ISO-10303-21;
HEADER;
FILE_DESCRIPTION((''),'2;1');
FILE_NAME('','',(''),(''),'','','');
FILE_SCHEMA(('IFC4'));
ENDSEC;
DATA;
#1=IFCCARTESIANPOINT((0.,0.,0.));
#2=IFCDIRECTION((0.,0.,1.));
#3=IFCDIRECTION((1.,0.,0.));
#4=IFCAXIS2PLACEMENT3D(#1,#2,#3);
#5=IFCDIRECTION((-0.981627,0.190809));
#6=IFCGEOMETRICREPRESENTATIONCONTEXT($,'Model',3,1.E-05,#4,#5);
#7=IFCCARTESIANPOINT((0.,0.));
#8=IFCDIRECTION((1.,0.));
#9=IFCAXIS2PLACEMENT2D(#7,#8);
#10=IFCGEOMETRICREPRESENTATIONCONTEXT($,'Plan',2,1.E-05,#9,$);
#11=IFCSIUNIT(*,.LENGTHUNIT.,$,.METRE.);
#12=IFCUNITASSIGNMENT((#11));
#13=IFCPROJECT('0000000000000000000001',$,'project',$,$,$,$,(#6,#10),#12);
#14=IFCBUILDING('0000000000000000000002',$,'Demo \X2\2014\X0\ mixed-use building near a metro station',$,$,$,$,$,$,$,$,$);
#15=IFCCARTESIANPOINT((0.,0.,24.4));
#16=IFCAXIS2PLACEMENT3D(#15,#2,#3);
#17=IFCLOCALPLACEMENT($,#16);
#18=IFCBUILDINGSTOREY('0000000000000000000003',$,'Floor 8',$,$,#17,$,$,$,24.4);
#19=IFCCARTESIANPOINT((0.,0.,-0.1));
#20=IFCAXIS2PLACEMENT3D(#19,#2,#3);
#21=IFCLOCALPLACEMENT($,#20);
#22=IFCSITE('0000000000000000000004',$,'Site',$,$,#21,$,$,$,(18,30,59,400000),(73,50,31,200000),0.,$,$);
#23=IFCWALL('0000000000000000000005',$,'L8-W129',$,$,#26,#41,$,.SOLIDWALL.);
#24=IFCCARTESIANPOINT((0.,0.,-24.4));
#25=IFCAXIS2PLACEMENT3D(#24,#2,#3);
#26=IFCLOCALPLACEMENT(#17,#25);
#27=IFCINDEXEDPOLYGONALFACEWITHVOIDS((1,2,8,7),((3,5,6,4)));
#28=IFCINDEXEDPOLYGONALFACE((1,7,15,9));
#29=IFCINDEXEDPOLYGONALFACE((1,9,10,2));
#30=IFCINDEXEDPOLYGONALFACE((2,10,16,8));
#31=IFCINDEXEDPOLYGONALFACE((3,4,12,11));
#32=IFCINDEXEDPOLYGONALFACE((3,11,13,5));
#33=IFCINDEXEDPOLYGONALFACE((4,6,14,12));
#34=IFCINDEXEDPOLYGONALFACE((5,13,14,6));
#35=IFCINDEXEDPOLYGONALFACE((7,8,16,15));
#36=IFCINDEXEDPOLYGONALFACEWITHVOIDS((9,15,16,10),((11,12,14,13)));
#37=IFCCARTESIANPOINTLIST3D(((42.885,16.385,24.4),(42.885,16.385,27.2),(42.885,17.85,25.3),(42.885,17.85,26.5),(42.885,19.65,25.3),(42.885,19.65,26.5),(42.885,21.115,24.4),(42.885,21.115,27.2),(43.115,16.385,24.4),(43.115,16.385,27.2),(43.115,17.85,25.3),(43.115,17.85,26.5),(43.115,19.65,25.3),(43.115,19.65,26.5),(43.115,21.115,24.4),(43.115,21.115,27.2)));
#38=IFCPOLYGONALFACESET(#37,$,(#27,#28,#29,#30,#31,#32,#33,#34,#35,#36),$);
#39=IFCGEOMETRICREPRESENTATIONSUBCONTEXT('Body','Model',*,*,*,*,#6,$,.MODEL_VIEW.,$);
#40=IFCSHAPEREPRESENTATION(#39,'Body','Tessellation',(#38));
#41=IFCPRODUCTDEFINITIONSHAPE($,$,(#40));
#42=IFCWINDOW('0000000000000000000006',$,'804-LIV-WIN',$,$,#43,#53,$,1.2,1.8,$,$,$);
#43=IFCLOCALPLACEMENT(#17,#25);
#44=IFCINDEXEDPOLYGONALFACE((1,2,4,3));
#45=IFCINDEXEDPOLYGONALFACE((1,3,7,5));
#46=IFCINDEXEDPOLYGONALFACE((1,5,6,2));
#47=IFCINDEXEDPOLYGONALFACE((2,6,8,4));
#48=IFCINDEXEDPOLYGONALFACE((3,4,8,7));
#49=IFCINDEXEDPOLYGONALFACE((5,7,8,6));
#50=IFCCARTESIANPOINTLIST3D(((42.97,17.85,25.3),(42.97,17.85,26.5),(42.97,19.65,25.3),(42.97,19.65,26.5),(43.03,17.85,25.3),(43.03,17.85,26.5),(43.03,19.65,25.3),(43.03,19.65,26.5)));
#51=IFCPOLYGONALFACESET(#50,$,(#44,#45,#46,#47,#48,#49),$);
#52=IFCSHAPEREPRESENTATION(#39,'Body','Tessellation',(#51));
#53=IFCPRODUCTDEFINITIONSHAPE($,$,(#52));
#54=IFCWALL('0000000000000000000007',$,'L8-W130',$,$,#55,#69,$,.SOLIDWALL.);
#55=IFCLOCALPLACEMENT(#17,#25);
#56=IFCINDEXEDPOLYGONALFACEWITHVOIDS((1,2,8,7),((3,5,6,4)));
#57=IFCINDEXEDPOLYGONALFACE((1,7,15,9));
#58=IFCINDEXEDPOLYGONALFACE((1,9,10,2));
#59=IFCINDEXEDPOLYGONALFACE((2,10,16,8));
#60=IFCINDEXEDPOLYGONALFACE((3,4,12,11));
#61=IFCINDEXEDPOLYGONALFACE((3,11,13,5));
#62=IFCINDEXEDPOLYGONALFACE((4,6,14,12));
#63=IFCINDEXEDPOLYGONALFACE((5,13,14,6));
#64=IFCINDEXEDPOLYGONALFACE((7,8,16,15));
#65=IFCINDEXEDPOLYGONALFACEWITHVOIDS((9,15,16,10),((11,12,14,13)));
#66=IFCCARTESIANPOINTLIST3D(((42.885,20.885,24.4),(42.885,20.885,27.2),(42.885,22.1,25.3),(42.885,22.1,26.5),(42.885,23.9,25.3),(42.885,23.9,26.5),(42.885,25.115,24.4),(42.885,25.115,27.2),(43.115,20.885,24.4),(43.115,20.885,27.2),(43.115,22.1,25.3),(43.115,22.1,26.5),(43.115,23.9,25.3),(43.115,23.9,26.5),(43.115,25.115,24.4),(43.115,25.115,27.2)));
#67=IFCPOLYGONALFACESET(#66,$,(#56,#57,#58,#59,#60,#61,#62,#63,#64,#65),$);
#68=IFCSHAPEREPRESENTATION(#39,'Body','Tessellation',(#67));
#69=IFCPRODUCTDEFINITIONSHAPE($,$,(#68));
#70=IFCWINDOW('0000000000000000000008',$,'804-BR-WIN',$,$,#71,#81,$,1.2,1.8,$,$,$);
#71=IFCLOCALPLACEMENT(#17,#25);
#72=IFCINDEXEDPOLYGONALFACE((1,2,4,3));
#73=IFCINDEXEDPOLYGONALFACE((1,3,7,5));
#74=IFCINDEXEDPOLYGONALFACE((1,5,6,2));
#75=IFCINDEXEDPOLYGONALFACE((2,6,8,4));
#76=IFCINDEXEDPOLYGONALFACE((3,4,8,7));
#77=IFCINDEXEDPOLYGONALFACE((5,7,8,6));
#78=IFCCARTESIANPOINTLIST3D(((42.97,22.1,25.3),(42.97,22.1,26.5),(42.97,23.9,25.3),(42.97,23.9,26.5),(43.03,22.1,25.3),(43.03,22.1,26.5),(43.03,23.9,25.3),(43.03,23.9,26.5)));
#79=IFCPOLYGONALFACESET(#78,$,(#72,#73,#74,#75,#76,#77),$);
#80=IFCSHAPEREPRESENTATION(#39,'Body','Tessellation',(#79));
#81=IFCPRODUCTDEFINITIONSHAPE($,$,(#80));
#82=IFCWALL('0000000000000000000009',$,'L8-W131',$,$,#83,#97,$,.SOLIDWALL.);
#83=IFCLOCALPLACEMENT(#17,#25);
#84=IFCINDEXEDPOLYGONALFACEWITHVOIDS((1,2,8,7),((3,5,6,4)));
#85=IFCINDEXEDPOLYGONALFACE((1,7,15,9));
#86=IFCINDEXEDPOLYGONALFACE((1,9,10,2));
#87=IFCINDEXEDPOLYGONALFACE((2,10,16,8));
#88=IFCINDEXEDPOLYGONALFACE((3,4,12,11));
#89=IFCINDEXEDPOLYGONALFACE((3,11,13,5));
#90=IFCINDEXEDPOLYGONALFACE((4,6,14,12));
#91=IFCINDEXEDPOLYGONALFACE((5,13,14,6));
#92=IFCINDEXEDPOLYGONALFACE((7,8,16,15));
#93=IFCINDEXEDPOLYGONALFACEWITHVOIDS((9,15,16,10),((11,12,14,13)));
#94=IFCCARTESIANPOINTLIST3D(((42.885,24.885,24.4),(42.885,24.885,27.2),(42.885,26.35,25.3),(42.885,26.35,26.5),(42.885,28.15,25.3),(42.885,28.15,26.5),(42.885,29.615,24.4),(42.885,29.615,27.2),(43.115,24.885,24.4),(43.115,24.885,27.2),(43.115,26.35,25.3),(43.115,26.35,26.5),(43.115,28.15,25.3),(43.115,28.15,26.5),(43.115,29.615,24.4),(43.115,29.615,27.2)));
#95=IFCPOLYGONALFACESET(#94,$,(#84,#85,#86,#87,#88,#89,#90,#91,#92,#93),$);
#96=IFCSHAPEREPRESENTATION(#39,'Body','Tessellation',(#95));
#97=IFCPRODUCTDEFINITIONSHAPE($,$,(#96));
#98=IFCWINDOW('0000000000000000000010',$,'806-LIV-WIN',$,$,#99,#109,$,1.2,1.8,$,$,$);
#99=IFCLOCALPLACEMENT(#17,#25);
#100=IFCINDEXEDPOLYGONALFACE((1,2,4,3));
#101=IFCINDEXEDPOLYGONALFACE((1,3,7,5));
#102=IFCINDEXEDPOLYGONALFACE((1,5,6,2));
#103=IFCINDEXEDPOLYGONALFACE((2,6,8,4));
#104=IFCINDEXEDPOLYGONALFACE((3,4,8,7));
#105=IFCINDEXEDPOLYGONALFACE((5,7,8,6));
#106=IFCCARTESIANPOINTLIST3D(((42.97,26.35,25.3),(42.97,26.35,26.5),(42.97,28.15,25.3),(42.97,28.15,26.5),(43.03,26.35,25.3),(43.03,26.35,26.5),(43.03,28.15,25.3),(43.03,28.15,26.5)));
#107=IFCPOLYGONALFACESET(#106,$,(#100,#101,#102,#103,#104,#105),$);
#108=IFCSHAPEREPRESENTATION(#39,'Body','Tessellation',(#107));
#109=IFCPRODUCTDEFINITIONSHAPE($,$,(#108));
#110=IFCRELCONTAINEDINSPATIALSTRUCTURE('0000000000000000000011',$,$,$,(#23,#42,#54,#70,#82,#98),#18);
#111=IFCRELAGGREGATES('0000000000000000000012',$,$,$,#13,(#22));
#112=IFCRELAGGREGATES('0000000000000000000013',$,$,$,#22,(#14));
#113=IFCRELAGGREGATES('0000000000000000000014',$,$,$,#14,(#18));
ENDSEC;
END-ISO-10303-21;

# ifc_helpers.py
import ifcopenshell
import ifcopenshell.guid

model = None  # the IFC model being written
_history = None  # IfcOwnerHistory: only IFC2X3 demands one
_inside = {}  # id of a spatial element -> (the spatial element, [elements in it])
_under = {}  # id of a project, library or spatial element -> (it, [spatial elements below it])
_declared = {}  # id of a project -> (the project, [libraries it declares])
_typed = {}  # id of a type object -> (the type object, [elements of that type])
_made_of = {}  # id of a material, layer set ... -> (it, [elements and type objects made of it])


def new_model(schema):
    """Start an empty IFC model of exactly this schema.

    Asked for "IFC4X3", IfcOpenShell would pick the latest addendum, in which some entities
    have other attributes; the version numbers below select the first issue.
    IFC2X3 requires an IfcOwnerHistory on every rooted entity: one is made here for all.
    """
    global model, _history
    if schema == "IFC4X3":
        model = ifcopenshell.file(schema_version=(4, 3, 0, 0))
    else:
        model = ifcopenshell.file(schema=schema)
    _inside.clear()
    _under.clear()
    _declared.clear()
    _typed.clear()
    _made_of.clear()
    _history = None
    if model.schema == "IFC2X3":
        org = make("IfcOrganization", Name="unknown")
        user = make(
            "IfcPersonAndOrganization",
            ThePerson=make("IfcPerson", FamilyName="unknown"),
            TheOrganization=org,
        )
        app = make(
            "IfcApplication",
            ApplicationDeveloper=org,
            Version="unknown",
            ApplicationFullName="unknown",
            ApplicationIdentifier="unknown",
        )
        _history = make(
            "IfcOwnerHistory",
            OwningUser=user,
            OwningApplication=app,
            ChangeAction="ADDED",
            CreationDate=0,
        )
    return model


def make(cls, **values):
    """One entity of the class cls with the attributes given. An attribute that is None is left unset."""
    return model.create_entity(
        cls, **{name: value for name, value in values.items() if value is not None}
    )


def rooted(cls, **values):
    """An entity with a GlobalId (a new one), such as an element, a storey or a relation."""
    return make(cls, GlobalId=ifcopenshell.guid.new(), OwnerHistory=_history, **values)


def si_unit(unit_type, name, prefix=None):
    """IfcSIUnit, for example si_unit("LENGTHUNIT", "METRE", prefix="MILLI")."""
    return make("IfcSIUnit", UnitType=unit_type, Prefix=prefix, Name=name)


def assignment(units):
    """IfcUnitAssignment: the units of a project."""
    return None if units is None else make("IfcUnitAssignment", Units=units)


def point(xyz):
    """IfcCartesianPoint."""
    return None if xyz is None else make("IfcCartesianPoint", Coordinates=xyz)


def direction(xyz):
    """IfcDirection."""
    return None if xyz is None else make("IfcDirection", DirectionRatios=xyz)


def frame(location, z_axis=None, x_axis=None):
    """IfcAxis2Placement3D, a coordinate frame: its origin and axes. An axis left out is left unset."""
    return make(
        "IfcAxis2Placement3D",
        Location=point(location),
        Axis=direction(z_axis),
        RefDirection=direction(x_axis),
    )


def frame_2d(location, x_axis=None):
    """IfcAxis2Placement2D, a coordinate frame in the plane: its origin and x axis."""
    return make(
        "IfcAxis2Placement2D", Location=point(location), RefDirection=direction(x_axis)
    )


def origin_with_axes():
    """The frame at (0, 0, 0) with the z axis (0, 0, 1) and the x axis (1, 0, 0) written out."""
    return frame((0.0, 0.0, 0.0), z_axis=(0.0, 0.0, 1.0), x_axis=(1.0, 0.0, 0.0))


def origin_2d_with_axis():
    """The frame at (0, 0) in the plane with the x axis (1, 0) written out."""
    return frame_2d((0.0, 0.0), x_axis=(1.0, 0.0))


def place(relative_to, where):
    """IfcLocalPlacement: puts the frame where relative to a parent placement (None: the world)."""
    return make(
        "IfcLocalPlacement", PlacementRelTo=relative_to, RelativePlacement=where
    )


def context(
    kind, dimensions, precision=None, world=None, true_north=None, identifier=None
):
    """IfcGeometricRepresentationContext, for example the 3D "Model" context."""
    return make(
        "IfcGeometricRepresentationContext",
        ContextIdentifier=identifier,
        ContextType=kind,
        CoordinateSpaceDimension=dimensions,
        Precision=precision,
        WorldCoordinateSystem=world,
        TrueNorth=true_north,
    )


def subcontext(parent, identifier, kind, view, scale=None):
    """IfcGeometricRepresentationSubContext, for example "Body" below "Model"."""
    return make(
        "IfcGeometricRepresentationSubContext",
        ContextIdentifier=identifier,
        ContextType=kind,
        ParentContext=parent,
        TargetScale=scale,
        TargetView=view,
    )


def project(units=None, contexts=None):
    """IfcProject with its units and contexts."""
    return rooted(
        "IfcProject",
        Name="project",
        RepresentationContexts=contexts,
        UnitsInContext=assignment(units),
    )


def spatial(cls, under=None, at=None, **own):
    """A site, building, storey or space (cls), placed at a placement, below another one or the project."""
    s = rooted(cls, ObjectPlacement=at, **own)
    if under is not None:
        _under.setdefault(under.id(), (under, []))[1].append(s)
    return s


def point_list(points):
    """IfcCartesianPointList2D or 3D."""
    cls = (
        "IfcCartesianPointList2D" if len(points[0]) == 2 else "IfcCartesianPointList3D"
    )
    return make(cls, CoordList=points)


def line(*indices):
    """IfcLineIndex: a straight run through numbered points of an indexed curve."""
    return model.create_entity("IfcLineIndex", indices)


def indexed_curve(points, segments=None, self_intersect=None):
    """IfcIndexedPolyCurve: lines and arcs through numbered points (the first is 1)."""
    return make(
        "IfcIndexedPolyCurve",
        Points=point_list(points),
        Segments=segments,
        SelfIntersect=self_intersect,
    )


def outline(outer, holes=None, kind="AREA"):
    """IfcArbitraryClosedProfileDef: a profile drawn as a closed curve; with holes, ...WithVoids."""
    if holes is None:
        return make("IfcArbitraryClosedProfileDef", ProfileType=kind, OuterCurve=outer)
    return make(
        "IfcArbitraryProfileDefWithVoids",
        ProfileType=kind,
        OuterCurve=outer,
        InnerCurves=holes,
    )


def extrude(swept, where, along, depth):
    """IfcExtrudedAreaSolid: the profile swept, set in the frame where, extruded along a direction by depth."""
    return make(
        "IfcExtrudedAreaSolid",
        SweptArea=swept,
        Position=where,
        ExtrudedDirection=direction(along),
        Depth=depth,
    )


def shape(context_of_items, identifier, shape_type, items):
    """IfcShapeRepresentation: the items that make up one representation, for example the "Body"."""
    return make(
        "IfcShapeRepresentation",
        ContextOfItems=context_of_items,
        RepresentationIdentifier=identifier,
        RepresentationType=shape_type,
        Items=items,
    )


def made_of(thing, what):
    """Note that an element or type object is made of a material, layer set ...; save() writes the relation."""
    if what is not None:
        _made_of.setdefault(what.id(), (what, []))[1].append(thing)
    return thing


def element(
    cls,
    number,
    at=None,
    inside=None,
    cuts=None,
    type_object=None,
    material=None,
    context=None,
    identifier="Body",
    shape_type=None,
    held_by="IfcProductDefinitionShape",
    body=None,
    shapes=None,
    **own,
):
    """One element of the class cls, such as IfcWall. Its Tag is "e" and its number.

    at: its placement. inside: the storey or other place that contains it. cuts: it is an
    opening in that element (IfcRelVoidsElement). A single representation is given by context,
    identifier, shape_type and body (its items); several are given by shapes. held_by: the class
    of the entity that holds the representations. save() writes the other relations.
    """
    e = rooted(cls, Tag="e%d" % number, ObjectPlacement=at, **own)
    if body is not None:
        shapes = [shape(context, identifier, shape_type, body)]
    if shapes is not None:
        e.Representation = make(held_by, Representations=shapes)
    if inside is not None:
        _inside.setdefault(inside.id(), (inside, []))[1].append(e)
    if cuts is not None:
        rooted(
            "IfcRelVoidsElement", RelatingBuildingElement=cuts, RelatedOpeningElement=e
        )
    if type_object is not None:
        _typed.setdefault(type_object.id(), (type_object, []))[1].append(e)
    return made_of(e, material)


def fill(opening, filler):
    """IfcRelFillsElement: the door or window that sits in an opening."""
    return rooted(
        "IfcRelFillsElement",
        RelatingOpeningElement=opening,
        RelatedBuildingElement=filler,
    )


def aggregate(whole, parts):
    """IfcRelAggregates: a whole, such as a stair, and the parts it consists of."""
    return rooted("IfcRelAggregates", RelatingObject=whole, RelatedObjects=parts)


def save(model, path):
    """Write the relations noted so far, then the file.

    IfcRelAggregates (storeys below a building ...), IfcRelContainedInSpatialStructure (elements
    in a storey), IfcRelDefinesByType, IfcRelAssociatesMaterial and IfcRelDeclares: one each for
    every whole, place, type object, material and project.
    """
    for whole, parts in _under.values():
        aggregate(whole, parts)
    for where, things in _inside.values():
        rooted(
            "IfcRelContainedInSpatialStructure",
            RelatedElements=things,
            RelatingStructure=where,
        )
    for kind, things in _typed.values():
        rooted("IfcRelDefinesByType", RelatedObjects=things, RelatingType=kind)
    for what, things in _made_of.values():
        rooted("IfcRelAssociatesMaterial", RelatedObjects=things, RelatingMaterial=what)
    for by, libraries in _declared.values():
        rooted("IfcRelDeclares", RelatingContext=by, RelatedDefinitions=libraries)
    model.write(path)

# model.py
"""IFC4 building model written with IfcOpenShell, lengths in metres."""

from ifc_helpers import new_model, si_unit, direction, frame, origin_with_axes, origin_2d_with_axis, place, context, subcontext, project, spatial, line, indexed_curve, outline, extrude, element, fill, save


model = new_model("IFC4")

# Units and contexts
model_context = context("Model", 3, precision=1e-05, world=origin_with_axes(), true_north=direction((-0.981627, 0.190809)))
plan_context = context("Plan", 2, precision=1e-05, world=origin_2d_with_axis())
body_context = subcontext(model_context, "Body", "Model", "MODEL_VIEW")
ifc_project = project(units=[si_unit("LENGTHUNIT", "METRE")], contexts=[model_context, plan_context])

# Site, building, storey
site_placement = place(None, frame((0.0, 0.0, -0.1), z_axis=(0.0, 0.0, 1.0), x_axis=(1.0, 0.0, 0.0)))
site = spatial("IfcSite", under=ifc_project, at=site_placement, Name="Site", RefLatitude=(18, 30, 59, 400000), RefLongitude=(73, 50, 31, 200000), RefElevation=0.0)
building = spatial("IfcBuilding", under=site, Name="Demo — mixed-use building near a metro station")
storey_placement = place(None, frame((0.0, 0.0, 24.4), z_axis=(0.0, 0.0, 1.0), x_axis=(1.0, 0.0, 0.0)))
storey = spatial("IfcBuildingStorey", under=building, at=storey_placement, Name="Floor 8", Elevation=24.4)

# Walls, openings, windows
wall_1_placement = place(storey_placement, frame((0.0, 0.0, -24.4), z_axis=(0.0, 0.0, 1.0), x_axis=(1.0, 0.0, 0.0)))
wall_1 = element("IfcWall", 1, at=wall_1_placement, inside=storey, Name="L8-W129", PredefinedType="SOLIDWALL", context=body_context, shape_type="SweptSolid", body=[
    extrude(outline(indexed_curve([(42.885, 16.385), (42.885, 21.115), (43.115, 21.115), (43.115, 16.385)], segments=[line(1, 2, 3, 4, 1)])), frame((0.0, 0.0, 24.4), z_axis=(0.0, 0.0, 1.0), x_axis=(1.0, 0.0, 0.0)), (0.0, 0.0, 1.0), 2.8),
])
opening_1_placement = place(wall_1_placement, origin_with_axes())
opening_1 = element("IfcOpeningElement", 2, at=opening_1_placement, cuts=wall_1, context=body_context, shape_type="SweptSolid", body=[
    extrude(outline(indexed_curve([(42.835, 17.85), (42.835, 19.65), (43.165, 19.65), (43.165, 17.85)], segments=[line(1, 2, 3, 4, 1)])), frame((0.0, 0.0, 25.3), z_axis=(0.0, 0.0, 1.0), x_axis=(1.0, 0.0, 0.0)), (0.0, 0.0, 1.0), 1.2),
])
window_1_placement = place(storey_placement, frame((0.0, 0.0, -24.4), z_axis=(0.0, 0.0, 1.0), x_axis=(1.0, 0.0, 0.0)))
window_1 = element("IfcWindow", 3, at=window_1_placement, inside=storey, Name="804-LIV-WIN", OverallHeight=1.2, OverallWidth=1.8, context=body_context, shape_type="SweptSolid", body=[
    extrude(outline(indexed_curve([(42.97, 17.85), (42.97, 19.65), (43.03, 19.65), (43.03, 17.85)], segments=[line(1, 2, 3, 4, 1)])), frame((0.0, 0.0, 25.3), z_axis=(0.0, 0.0, 1.0), x_axis=(1.0, 0.0, 0.0)), (0.0, 0.0, 1.0), 1.2),
])
fill(opening_1, window_1)
wall_2_placement = place(storey_placement, frame((0.0, 0.0, -24.4), z_axis=(0.0, 0.0, 1.0), x_axis=(1.0, 0.0, 0.0)))
wall_2 = element("IfcWall", 4, at=wall_2_placement, inside=storey, Name="L8-W130", PredefinedType="SOLIDWALL", context=body_context, shape_type="SweptSolid", body=[
    extrude(outline(indexed_curve([(42.885, 20.885), (42.885, 25.115), (43.115, 25.115), (43.115, 20.885)], segments=[line(1, 2, 3, 4, 1)])), frame((0.0, 0.0, 24.4), z_axis=(0.0, 0.0, 1.0), x_axis=(1.0, 0.0, 0.0)), (0.0, 0.0, 1.0), 2.8),
])
opening_2_placement = place(wall_2_placement, origin_with_axes())
opening_2 = element("IfcOpeningElement", 5, at=opening_2_placement, cuts=wall_2, context=body_context, shape_type="SweptSolid", body=[
    extrude(outline(indexed_curve([(42.835, 22.1), (42.835, 23.9), (43.165, 23.9), (43.165, 22.1)], segments=[line(1, 2, 3, 4, 1)])), frame((0.0, 0.0, 25.3), z_axis=(0.0, 0.0, 1.0), x_axis=(1.0, 0.0, 0.0)), (0.0, 0.0, 1.0), 1.2),
])
window_2_placement = place(storey_placement, frame((0.0, 0.0, -24.4), z_axis=(0.0, 0.0, 1.0), x_axis=(1.0, 0.0, 0.0)))
window_2 = element("IfcWindow", 6, at=window_2_placement, inside=storey, Name="804-BR-WIN", OverallHeight=1.2, OverallWidth=1.8, context=body_context, shape_type="SweptSolid", body=[
    extrude(outline(indexed_curve([(42.97, 22.1), (42.97, 23.9), (43.03, 23.9), (43.03, 22.1)], segments=[line(1, 2, 3, 4, 1)])), frame((0.0, 0.0, 25.3), z_axis=(0.0, 0.0, 1.0), x_axis=(1.0, 0.0, 0.0)), (0.0, 0.0, 1.0), 1.2),
])
fill(opening_2, window_2)
wall_3_placement = place(storey_placement, frame((0.0, 0.0, -24.4), z_axis=(0.0, 0.0, 1.0), x_axis=(1.0, 0.0, 0.0)))
wall_3 = element("IfcWall", 7, at=wall_3_placement, inside=storey, Name="L8-W131", PredefinedType="SOLIDWALL", context=body_context, shape_type="SweptSolid", body=[
    extrude(outline(indexed_curve([(42.885, 24.885), (42.885, 29.615), (43.115, 29.615), (43.115, 24.885)], segments=[line(1, 2, 3, 4, 1)])), frame((0.0, 0.0, 24.4), z_axis=(0.0, 0.0, 1.0), x_axis=(1.0, 0.0, 0.0)), (0.0, 0.0, 1.0), 2.8),
])
opening_3_placement = place(wall_3_placement, origin_with_axes())
opening_3 = element("IfcOpeningElement", 8, at=opening_3_placement, cuts=wall_3, context=body_context, shape_type="SweptSolid", body=[
    extrude(outline(indexed_curve([(42.835, 26.35), (42.835, 28.15), (43.165, 28.15), (43.165, 26.35)], segments=[line(1, 2, 3, 4, 1)])), frame((0.0, 0.0, 25.3), z_axis=(0.0, 0.0, 1.0), x_axis=(1.0, 0.0, 0.0)), (0.0, 0.0, 1.0), 1.2),
])
window_3_placement = place(storey_placement, frame((0.0, 0.0, -24.4), z_axis=(0.0, 0.0, 1.0), x_axis=(1.0, 0.0, 0.0)))
window_3 = element("IfcWindow", 9, at=window_3_placement, inside=storey, Name="806-LIV-WIN", OverallHeight=1.2, OverallWidth=1.8, context=body_context, shape_type="SweptSolid", body=[
    extrude(outline(indexed_curve([(42.97, 26.35), (42.97, 28.15), (43.03, 28.15), (43.03, 26.35)], segments=[line(1, 2, 3, 4, 1)])), frame((0.0, 0.0, 25.3), z_axis=(0.0, 0.0, 1.0), x_axis=(1.0, 0.0, 0.0)), (0.0, 0.0, 1.0), 1.2),
])
fill(opening_3, window_3)

save(model, "model.ifc")
